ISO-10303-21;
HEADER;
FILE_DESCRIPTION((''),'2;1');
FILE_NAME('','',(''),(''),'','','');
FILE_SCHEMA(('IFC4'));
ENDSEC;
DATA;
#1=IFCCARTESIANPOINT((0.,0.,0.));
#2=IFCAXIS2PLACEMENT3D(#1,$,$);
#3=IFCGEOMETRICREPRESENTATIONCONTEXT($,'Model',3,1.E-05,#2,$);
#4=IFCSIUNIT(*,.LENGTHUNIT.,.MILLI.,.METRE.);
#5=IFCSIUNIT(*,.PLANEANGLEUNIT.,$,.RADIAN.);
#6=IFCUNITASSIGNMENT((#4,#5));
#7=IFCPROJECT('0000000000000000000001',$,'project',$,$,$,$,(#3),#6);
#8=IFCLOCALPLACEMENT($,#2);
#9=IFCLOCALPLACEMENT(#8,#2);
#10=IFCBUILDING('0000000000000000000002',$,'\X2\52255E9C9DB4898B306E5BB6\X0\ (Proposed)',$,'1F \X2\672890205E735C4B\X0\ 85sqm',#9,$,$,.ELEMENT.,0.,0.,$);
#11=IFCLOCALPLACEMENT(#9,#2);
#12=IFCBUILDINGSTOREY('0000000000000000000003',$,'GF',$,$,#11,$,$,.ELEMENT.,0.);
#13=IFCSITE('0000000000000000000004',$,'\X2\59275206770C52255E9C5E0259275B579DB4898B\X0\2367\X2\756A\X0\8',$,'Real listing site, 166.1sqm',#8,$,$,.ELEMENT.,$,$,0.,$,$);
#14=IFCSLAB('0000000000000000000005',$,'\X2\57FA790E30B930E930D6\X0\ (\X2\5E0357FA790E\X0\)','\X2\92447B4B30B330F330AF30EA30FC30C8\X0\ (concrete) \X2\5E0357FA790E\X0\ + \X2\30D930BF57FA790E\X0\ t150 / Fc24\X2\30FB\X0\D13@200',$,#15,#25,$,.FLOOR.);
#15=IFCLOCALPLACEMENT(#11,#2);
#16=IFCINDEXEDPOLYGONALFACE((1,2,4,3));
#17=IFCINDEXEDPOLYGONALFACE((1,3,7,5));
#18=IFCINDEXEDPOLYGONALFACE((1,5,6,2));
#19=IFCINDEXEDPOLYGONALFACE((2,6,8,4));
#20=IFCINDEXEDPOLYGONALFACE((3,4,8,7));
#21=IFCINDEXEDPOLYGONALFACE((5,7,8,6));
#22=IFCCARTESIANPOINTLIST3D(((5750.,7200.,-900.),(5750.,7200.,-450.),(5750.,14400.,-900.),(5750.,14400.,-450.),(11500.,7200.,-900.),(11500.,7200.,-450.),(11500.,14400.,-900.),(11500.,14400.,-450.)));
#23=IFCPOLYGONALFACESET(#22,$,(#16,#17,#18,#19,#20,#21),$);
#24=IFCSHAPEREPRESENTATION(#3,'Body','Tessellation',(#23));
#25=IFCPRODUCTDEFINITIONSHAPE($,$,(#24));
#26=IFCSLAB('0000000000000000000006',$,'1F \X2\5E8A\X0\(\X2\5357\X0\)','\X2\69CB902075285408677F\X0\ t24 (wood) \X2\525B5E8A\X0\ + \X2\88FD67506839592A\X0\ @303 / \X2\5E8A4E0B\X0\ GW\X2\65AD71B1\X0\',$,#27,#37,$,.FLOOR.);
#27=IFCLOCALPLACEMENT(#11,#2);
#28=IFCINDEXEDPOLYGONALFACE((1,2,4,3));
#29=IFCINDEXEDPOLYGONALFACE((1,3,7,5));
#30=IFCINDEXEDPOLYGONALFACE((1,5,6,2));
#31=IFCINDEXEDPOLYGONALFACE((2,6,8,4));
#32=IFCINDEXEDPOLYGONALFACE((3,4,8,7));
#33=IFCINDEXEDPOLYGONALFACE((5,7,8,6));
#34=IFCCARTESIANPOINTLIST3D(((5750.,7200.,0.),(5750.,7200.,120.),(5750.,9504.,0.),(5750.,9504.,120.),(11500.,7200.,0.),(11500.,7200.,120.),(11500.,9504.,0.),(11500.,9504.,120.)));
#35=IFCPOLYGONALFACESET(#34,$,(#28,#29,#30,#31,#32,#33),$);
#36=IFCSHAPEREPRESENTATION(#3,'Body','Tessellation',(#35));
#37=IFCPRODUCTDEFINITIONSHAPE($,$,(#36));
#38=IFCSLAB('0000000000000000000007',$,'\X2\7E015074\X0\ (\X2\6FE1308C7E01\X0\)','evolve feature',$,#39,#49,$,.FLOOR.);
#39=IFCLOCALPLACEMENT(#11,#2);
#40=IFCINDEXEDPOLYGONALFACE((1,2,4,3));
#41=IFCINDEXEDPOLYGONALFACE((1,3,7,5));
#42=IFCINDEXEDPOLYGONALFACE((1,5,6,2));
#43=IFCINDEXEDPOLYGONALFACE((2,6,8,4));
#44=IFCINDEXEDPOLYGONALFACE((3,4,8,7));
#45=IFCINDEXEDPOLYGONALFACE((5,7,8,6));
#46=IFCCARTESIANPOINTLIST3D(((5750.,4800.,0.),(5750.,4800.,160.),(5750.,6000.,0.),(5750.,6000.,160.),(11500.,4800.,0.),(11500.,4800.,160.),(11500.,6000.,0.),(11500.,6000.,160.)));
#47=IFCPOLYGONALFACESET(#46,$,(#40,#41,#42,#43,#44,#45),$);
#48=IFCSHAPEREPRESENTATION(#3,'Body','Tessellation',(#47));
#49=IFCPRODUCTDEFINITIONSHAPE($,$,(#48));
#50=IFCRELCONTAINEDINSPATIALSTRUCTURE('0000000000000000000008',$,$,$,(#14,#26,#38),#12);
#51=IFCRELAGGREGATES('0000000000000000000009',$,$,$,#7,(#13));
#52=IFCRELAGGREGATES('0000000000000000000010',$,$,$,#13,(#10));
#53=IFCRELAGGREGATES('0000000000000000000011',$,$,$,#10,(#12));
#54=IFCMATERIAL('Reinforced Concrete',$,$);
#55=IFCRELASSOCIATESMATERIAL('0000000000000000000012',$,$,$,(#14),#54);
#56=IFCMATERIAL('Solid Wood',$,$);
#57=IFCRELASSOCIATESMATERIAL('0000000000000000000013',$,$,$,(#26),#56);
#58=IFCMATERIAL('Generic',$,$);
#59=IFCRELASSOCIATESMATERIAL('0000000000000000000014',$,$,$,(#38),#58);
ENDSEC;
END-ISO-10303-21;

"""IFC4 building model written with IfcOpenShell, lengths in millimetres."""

from ifc_helpers import new_model, si_unit, frame, frame_2d, origin, place, context, project, spatial, rectangle, extrude, material, element, save


model = new_model("IFC4")

# Units and contexts
model_context = context("Model", 3, precision=1e-05, world=origin())
ifc_project = project(units=[si_unit("LENGTHUNIT", "METRE", prefix="MILLI"), si_unit("PLANEANGLEUNIT", "RADIAN")], contexts=[model_context])

# Site, building, storey
site_placement = place(None, origin())
site = spatial("IfcSite", under=ifc_project, at=site_placement, Name="大分県別府市大字鶴見2367番8", ObjectType="Real listing site, 166.1sqm", CompositionType="ELEMENT", RefElevation=0.0)
building_placement = place(site_placement, origin())
building = spatial("IfcBuilding", under=site, at=building_placement, Name="別府鶴見の家 (Proposed)", ObjectType="1F 木造平屋 85sqm", CompositionType="ELEMENT", ElevationOfRefHeight=0.0, ElevationOfTerrain=0.0)
storey_placement = place(building_placement, origin())
storey = spatial("IfcBuildingStorey", under=building, at=storey_placement, Name="GF", CompositionType="ELEMENT", Elevation=0.0)

# Slabs
ifc_material_1 = material(Name="Reinforced Concrete")
slab_1_placement = place(storey_placement, frame((2875.0, 3600.0, -450.0)))
element("IfcSlab", 1, at=slab_1_placement, inside=storey, material=ifc_material_1, Name="基礎スラブ (布基礎)", Description="鉄筋コンクリート (concrete) 布基礎 + ベタ基礎 t150 / Fc24・D13@200", PredefinedType="FLOOR", context=model_context, shape_type="SweptSolid", body=[
    extrude(rectangle(XDim=5750.0, YDim=7200.0, at=frame_2d((2875.0, 3600.0))), frame((2875.0, 3600.0, -450.0)), (0.0, 0.0, 1.0), 450.0),
])
ifc_material_2 = material(Name="Solid Wood")
slab_2_placement = place(storey_placement, frame((2875.0, 3600.0, 0.0)))
element("IfcSlab", 2, at=slab_2_placement, inside=storey, material=ifc_material_2, Name="1F 床(南)", Description="構造用合板 t24 (wood) 剛床 + 製材根太 @303 / 床下 GW断熱", PredefinedType="FLOOR", context=model_context, shape_type="SweptSolid", body=[
    extrude(rectangle(XDim=5750.0, YDim=2304.0, at=frame_2d((2875.0, 1152.0))), frame((2875.0, 3600.0, 0.0)), (0.0, 0.0, 1.0), 120.0),
])
ifc_material_3 = material(Name="Generic")
slab_3_placement = place(storey_placement, frame((2875.0, 2400.0, 0.0)))
element("IfcSlab", 3, at=slab_3_placement, inside=storey, material=ifc_material_3, Name="縁側 (濡れ縁)", Description="evolve feature", PredefinedType="FLOOR", context=model_context, shape_type="SweptSolid", body=[
    extrude(rectangle(XDim=5750.0, YDim=1200.0, at=frame_2d((2875.0, 600.0))), frame((2875.0, 2400.0, 0.0)), (0.0, 0.0, 1.0), 160.0),
])

save(model, "model.ifc")
